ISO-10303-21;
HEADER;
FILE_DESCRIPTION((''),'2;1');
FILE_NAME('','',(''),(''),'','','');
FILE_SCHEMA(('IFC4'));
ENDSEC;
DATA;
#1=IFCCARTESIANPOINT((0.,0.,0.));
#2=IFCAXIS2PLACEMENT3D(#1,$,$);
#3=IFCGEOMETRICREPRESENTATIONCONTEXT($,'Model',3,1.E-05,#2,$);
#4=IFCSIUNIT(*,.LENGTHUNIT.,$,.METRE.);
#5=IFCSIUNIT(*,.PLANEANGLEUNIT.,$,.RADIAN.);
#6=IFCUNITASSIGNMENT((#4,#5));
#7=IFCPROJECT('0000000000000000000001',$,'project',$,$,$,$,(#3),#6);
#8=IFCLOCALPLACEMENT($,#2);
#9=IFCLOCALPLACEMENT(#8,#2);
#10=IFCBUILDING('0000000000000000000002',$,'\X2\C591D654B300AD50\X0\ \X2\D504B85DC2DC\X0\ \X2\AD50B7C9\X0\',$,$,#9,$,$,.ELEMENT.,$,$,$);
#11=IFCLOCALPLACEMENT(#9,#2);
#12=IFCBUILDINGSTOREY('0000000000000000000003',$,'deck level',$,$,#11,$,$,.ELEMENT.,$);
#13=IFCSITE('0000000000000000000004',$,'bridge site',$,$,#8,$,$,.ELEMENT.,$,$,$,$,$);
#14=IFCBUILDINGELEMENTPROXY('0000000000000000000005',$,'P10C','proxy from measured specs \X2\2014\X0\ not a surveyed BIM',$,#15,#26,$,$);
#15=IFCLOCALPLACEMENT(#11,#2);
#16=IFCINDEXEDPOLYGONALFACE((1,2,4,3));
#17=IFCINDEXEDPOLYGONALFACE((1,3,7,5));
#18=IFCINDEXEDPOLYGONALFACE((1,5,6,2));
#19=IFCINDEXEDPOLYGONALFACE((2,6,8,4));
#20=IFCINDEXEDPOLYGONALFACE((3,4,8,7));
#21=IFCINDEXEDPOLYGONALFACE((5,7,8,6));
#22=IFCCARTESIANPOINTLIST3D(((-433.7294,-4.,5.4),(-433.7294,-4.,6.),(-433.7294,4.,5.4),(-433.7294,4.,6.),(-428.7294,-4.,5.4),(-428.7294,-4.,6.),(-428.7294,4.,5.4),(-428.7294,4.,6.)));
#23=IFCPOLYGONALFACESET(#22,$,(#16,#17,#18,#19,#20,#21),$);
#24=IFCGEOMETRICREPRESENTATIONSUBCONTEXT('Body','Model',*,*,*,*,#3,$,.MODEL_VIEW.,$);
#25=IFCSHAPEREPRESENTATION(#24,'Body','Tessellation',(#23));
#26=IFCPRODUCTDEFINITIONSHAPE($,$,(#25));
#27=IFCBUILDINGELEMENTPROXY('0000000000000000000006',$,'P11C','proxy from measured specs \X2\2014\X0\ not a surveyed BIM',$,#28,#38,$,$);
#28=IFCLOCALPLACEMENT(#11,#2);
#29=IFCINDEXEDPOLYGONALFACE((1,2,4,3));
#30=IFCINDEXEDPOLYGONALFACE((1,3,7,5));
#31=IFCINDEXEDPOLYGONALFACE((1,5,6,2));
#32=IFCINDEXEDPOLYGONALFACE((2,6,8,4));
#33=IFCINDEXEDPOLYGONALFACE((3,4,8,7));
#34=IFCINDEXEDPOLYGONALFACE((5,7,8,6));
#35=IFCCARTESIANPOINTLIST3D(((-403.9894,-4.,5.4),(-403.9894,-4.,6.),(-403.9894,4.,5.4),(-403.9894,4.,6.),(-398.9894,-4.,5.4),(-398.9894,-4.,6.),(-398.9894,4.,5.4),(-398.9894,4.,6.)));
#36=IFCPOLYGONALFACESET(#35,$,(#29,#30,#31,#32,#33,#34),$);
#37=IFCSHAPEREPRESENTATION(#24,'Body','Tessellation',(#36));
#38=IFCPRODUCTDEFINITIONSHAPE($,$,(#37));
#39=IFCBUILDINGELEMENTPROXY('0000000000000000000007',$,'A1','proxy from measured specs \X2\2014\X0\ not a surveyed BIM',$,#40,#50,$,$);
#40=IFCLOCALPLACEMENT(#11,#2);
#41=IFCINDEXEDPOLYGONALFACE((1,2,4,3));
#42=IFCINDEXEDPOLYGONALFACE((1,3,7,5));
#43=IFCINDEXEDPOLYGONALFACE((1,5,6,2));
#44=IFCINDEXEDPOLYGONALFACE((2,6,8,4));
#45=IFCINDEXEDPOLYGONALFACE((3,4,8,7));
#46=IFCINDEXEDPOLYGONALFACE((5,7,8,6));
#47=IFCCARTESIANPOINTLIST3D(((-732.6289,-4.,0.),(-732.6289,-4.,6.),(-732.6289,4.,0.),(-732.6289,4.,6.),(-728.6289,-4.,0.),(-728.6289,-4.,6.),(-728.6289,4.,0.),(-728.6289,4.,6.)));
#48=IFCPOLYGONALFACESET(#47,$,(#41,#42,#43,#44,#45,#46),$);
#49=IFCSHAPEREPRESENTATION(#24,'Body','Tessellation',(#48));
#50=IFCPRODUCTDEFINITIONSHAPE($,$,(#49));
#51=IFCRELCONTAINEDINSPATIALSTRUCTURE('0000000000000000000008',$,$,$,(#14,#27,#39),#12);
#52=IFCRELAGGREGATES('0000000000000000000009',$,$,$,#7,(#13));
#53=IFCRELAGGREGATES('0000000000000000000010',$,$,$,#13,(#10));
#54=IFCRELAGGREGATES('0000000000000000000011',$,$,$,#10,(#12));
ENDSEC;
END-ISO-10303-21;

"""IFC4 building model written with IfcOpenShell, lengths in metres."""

from ifc_helpers import new_model, si_unit, frame, origin, origin_2d, place, context, subcontext, project, spatial, rectangle, extrude, element, save


model = new_model("IFC4")

# Units and contexts
model_context = context("Model", 3, precision=1e-05, world=origin())
body_context = subcontext(model_context, "Body", "Model", "MODEL_VIEW")
ifc_project = project(units=[si_unit("LENGTHUNIT", "METRE"), si_unit("PLANEANGLEUNIT", "RADIAN")], contexts=[model_context])

# Site, building, storey
site_placement = place(None, origin())
site = spatial("IfcSite", under=ifc_project, at=site_placement, Name="bridge site", CompositionType="ELEMENT")
building_placement = place(site_placement, origin())
building = spatial("IfcBuilding", under=site, at=building_placement, Name="양화대교 프록시 교량", CompositionType="ELEMENT")
storey_placement = place(building_placement, origin())
storey = spatial("IfcBuildingStorey", under=building, at=storey_placement, Name="deck level", CompositionType="ELEMENT")

# Building element proxies
for number, where, name in (
    (1, (-431.2294, 0.0, 5.4), "P10C"),
    (2, (-401.4894, 0.0, 5.4), "P11C"),
):
    element("IfcBuildingElementProxy", number, at=place(storey_placement, frame(where)), inside=storey, Name=name, Description="proxy from measured specs — not a surveyed BIM", context=body_context, shape_type="SweptSolid", body=[
        extrude(rectangle(XDim=5.0, YDim=8.0, at=origin_2d()), origin(), (0.0, 0.0, 1.0), 0.6),
    ])
proxy_placement = place(storey_placement, frame((-730.6289, 0.0, 0.0)))
element("IfcBuildingElementProxy", 3, at=proxy_placement, inside=storey, Name="A1", Description="proxy from measured specs — not a surveyed BIM", context=body_context, shape_type="SweptSolid", body=[
    extrude(rectangle(XDim=4.0, YDim=8.0, at=origin_2d()), origin(), (0.0, 0.0, 1.0), 6.0),
])

save(model, "model.ifc")
